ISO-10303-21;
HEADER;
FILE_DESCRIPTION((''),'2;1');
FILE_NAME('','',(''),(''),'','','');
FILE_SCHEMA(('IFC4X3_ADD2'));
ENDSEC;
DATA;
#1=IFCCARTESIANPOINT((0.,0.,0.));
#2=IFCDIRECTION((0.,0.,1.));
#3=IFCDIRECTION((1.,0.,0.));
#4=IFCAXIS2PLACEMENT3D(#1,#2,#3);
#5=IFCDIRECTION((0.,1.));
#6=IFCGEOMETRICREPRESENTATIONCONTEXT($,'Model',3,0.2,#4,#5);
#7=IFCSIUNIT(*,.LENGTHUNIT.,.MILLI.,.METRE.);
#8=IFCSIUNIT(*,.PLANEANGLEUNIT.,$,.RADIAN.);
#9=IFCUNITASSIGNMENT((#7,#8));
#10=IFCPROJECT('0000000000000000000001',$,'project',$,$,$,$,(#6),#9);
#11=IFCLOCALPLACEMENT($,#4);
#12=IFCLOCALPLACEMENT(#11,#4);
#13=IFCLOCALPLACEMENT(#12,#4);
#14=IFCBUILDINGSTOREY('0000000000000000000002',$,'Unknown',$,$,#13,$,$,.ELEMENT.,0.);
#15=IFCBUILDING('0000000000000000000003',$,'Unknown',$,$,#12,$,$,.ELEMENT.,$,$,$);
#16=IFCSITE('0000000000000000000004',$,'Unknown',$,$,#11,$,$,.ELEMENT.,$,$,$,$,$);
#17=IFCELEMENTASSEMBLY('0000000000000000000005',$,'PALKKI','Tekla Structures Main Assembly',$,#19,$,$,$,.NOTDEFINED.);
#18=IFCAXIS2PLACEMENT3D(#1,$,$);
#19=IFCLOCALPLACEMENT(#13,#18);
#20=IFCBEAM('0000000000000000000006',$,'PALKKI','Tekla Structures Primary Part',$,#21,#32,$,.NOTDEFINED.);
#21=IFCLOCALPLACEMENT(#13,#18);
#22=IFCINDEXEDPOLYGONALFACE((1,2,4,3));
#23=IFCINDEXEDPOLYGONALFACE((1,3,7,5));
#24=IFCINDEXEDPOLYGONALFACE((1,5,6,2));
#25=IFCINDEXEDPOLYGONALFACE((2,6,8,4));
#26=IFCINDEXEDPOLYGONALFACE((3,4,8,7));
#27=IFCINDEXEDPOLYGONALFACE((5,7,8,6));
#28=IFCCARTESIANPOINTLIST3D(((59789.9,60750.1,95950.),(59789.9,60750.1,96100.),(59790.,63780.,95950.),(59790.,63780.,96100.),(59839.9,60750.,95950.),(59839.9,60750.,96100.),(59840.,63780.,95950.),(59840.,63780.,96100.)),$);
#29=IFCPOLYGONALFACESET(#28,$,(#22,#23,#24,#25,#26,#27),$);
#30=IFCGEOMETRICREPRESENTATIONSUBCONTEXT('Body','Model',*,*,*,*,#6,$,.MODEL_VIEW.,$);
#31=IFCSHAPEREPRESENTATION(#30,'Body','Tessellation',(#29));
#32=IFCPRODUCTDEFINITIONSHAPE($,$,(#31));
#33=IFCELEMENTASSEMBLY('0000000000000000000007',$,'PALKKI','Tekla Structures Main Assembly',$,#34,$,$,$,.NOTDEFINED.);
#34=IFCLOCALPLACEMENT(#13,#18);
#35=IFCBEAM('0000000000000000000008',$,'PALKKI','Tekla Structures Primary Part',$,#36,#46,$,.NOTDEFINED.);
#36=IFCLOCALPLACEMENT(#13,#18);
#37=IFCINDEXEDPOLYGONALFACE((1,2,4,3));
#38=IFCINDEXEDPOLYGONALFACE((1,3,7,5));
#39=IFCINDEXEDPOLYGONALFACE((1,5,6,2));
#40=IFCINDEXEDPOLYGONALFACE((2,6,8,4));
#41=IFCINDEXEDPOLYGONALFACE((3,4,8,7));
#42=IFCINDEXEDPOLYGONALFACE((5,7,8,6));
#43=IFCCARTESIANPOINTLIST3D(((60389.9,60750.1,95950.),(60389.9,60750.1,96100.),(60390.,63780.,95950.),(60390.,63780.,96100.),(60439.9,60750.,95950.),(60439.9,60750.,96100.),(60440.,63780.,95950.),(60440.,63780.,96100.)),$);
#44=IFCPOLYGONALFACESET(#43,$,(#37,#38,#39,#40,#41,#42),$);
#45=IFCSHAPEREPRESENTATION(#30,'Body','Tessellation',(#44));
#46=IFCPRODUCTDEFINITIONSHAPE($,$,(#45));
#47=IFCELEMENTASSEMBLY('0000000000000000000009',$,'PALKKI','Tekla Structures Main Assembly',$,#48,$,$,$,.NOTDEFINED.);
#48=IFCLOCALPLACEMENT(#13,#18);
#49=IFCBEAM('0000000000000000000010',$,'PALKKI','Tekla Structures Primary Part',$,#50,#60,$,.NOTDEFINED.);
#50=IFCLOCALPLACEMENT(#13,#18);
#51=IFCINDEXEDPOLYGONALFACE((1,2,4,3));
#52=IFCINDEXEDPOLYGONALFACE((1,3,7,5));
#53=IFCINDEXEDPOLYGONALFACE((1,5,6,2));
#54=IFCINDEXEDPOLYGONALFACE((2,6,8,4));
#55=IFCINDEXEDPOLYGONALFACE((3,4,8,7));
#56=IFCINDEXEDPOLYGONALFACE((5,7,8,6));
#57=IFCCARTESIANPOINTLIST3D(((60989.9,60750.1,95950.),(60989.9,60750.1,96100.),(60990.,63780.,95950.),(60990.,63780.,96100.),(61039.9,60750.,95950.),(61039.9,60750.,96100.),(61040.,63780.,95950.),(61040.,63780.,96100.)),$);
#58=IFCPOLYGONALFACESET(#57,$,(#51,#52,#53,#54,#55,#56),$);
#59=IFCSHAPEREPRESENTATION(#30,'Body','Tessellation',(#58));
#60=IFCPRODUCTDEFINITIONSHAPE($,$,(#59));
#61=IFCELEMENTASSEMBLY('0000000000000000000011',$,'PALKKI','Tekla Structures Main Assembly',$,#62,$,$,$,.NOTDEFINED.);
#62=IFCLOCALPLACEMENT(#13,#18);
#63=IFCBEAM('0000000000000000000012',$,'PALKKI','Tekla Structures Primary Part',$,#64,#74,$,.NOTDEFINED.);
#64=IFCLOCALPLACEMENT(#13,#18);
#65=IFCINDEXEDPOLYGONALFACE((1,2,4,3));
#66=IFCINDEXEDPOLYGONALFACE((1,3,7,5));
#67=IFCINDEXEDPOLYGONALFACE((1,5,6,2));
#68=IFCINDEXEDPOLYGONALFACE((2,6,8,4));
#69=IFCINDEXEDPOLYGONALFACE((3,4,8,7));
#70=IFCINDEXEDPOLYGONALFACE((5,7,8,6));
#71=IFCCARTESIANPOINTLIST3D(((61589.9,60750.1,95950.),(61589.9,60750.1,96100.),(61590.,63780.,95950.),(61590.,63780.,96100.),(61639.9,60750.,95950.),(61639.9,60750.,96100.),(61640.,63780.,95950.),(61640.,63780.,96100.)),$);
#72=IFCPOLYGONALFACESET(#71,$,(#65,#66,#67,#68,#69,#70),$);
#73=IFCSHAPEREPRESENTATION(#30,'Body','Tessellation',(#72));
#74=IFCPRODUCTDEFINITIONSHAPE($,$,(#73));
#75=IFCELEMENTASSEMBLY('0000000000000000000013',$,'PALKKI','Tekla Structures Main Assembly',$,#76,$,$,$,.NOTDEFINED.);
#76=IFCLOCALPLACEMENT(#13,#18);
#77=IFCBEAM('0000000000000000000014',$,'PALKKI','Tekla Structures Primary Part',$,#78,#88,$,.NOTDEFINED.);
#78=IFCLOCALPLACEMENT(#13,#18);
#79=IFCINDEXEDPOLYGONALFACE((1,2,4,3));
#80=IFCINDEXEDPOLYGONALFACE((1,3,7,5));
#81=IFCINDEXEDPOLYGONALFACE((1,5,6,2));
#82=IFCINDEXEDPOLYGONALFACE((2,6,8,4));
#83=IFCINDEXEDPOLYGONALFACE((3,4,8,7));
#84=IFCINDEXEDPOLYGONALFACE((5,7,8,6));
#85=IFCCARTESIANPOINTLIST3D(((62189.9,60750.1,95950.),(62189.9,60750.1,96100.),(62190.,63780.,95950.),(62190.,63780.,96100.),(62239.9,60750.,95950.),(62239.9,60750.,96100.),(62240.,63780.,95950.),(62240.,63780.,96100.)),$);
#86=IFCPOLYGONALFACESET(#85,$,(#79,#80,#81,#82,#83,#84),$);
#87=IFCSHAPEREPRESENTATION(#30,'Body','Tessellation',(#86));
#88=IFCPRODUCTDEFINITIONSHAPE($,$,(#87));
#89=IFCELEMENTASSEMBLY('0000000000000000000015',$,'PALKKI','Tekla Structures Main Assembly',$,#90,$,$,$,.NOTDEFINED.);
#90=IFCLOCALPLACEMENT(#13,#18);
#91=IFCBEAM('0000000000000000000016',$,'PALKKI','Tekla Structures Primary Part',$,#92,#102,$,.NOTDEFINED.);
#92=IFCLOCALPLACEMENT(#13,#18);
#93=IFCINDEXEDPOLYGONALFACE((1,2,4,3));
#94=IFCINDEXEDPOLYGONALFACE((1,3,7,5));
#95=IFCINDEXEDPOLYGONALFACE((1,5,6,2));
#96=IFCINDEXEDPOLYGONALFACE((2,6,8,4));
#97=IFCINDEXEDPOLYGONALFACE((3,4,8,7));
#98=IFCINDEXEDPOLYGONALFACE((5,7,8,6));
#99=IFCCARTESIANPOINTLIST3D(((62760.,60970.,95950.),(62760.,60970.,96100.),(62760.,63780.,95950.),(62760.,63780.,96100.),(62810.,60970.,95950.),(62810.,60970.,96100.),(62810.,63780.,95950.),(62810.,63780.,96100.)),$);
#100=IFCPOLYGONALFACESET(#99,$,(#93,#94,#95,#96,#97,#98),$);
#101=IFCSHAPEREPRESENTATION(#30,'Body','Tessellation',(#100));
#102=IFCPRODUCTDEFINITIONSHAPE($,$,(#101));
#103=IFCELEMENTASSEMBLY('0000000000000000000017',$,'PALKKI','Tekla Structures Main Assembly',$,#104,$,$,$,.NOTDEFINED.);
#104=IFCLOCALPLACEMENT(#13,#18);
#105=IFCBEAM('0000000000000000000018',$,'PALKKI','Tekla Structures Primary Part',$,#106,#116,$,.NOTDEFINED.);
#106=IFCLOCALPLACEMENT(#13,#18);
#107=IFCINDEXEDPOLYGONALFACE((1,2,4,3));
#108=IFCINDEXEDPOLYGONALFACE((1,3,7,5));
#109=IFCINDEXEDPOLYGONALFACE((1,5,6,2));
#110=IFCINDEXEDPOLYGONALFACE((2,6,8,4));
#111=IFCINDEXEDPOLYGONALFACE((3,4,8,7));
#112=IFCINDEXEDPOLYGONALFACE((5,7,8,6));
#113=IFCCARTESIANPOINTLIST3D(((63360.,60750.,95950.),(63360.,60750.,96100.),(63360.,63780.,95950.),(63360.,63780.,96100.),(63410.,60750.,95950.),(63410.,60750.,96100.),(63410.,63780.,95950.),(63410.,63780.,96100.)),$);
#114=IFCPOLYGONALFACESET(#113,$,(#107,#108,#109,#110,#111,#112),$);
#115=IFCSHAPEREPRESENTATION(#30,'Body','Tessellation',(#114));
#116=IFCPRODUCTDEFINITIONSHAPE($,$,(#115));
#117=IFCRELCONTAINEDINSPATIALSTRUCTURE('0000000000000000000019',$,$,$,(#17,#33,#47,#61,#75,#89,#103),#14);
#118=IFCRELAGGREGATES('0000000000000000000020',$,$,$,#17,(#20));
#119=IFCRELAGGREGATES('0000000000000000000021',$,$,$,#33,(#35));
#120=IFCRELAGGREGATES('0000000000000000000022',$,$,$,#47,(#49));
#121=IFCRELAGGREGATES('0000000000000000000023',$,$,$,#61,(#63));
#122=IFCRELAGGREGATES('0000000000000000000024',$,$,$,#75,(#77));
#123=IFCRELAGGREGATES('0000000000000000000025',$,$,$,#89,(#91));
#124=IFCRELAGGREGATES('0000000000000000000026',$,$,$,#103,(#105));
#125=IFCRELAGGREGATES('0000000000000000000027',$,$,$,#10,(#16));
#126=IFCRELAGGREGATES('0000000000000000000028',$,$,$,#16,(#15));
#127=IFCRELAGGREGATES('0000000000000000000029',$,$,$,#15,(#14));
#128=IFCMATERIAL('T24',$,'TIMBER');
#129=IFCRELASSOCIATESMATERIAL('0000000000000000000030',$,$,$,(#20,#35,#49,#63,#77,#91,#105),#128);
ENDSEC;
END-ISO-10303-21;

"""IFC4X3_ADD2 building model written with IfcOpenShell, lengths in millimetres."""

from ifc_helpers import new_model, si_unit, direction, frame, origin_with_axes, place, context, subcontext, project, spatial, line, indexed_curve, outline, extrude, material, element, aggregate, save


model = new_model("IFC4X3_ADD2")

# Units and contexts
model_context = context("Model", 3, precision=0.2, world=origin_with_axes(), true_north=direction((0.0, 1.0)))
body_context = subcontext(model_context, "Body", "Model", "MODEL_VIEW")
ifc_project = project(units=[si_unit("LENGTHUNIT", "METRE", prefix="MILLI"), si_unit("PLANEANGLEUNIT", "RADIAN")], contexts=[model_context])

# Site, building, storey
site_placement = place(None, origin_with_axes())
site = spatial("IfcSite", under=ifc_project, at=site_placement, Name="Unknown", CompositionType="ELEMENT")
building_placement = place(site_placement, origin_with_axes())
building = spatial("IfcBuilding", under=site, at=building_placement, Name="Unknown", CompositionType="ELEMENT")
storey_placement = place(building_placement, origin_with_axes())
storey = spatial("IfcBuildingStorey", under=building, at=storey_placement, Name="Unknown", CompositionType="ELEMENT", Elevation=0.0)

# Element assemblies, beams
ifc_material_1 = material(Name="T24", Category="TIMBER")
assembly_1_placement = place(storey_placement, frame((59815.0, 63780.0, 96025.0), z_axis=(-1.0, 0.000016, 0.0), x_axis=(-0.000016, -1.0, 0.0)))
assembly_1 = element("IfcElementAssembly", 1, at=assembly_1_placement, inside=storey, Name="PALKKI", Description="Tekla Structures Main Assembly", PredefinedType="NOTDEFINED")
beam_1_placement = place(assembly_1_placement, origin_with_axes())
beam_1 = element("IfcBeam", 2, at=beam_1_placement, material=ifc_material_1, Name="PALKKI", Description="Tekla Structures Primary Part", PredefinedType="NOTDEFINED", context=body_context, shape_type="SolidModel", body=[
    extrude(outline(indexed_curve([(-25.0, -75.0), (25.0, -75.0), (25.0, 75.0), (-25.0, 75.0)], segments=[line(1, 2, 3, 4, 1)])), frame((0.0, 0.0, 0.0), z_axis=(-1.0, 0.0, 0.0), x_axis=(0.0, 0.0, 1.0)), (0.0, 0.0, -1.0), 3029.9),
])
aggregate(assembly_1, [beam_1])
assembly_2_placement = place(storey_placement, frame((60415.0, 63780.0, 96025.0), z_axis=(-1.0, 0.000016, 0.0), x_axis=(-0.000016, -1.0, 0.0)))
assembly_2 = element("IfcElementAssembly", 3, at=assembly_2_placement, inside=storey, Name="PALKKI", Description="Tekla Structures Main Assembly", PredefinedType="NOTDEFINED")
beam_2_placement = place(assembly_2_placement, origin_with_axes())
beam_2 = element("IfcBeam", 4, at=beam_2_placement, material=ifc_material_1, Name="PALKKI", Description="Tekla Structures Primary Part", PredefinedType="NOTDEFINED", context=body_context, shape_type="SolidModel", body=[
    extrude(outline(indexed_curve([(-25.0, -75.0), (25.0, -75.0), (25.0, 75.0), (-25.0, 75.0)], segments=[line(1, 2, 3, 4, 1)])), frame((0.0, 0.0, 0.0), z_axis=(-1.0, 0.0, 0.0), x_axis=(0.0, 0.0, 1.0)), (0.0, 0.0, -1.0), 3029.9),
])
aggregate(assembly_2, [beam_2])
assembly_3_placement = place(storey_placement, frame((61015.0, 63780.0, 96025.0), z_axis=(-1.0, 0.000016, 0.0), x_axis=(-0.000016, -1.0, 0.0)))
assembly_3 = element("IfcElementAssembly", 5, at=assembly_3_placement, inside=storey, Name="PALKKI", Description="Tekla Structures Main Assembly", PredefinedType="NOTDEFINED")
beam_3_placement = place(assembly_3_placement, origin_with_axes())
beam_3 = element("IfcBeam", 6, at=beam_3_placement, material=ifc_material_1, Name="PALKKI", Description="Tekla Structures Primary Part", PredefinedType="NOTDEFINED", context=body_context, shape_type="SolidModel", body=[
    extrude(outline(indexed_curve([(-25.0, -75.0), (25.0, -75.0), (25.0, 75.0), (-25.0, 75.0)], segments=[line(1, 2, 3, 4, 1)])), frame((0.0, 0.0, 0.0), z_axis=(-1.0, 0.0, 0.0), x_axis=(0.0, 0.0, 1.0)), (0.0, 0.0, -1.0), 3029.9),
])
aggregate(assembly_3, [beam_3])
assembly_4_placement = place(storey_placement, frame((61615.0, 63780.0, 96025.0), z_axis=(-1.0, 0.000016, 0.0), x_axis=(-0.000016, -1.0, 0.0)))
assembly_4 = element("IfcElementAssembly", 7, at=assembly_4_placement, inside=storey, Name="PALKKI", Description="Tekla Structures Main Assembly", PredefinedType="NOTDEFINED")
beam_4_placement = place(assembly_4_placement, origin_with_axes())
beam_4 = element("IfcBeam", 8, at=beam_4_placement, material=ifc_material_1, Name="PALKKI", Description="Tekla Structures Primary Part", PredefinedType="NOTDEFINED", context=body_context, shape_type="SolidModel", body=[
    extrude(outline(indexed_curve([(-25.0, -75.0), (25.0, -75.0), (25.0, 75.0), (-25.0, 75.0)], segments=[line(1, 2, 3, 4, 1)])), frame((0.0, 0.0, 0.0), z_axis=(-1.0, 0.0, 0.0), x_axis=(0.0, 0.0, 1.0)), (0.0, 0.0, -1.0), 3029.9),
])
aggregate(assembly_4, [beam_4])
assembly_5_placement = place(storey_placement, frame((62215.0, 63780.0, 96025.0), z_axis=(-1.0, 0.000016, 0.0), x_axis=(-0.000016, -1.0, 0.0)))
assembly_5 = element("IfcElementAssembly", 9, at=assembly_5_placement, inside=storey, Name="PALKKI", Description="Tekla Structures Main Assembly", PredefinedType="NOTDEFINED")
beam_5_placement = place(assembly_5_placement, origin_with_axes())
beam_5 = element("IfcBeam", 10, at=beam_5_placement, material=ifc_material_1, Name="PALKKI", Description="Tekla Structures Primary Part", PredefinedType="NOTDEFINED", context=body_context, shape_type="SolidModel", body=[
    extrude(outline(indexed_curve([(-25.0, -75.0), (25.0, -75.0), (25.0, 75.0), (-25.0, 75.0)], segments=[line(1, 2, 3, 4, 1)])), frame((0.0, 0.0, 0.0), z_axis=(-1.0, 0.0, 0.0), x_axis=(0.0, 0.0, 1.0)), (0.0, 0.0, -1.0), 3029.9),
])
aggregate(assembly_5, [beam_5])
assembly_6_placement = place(storey_placement, frame((62785.0, 63780.0, 96025.0), z_axis=(-1.0, 0.000016, 0.0), x_axis=(-0.000016, -1.0, 0.0)))
assembly_6 = element("IfcElementAssembly", 11, at=assembly_6_placement, inside=storey, Name="PALKKI", Description="Tekla Structures Main Assembly", PredefinedType="NOTDEFINED")
beam_6_placement = place(assembly_6_placement, origin_with_axes())
beam_6 = element("IfcBeam", 12, at=beam_6_placement, material=ifc_material_1, Name="PALKKI", Description="Tekla Structures Primary Part", PredefinedType="NOTDEFINED", context=body_context, shape_type="SolidModel", body=[
    extrude(outline(indexed_curve([(-25.0, -75.0), (25.0, -75.0), (25.0, 75.0), (-25.0, 75.0)], segments=[line(1, 2, 3, 4, 1)])), frame((0.0, 0.0, 0.0), z_axis=(-1.0, 0.0, 0.0), x_axis=(0.0, 0.0, 1.0)), (0.0, 0.0, -1.0), 2809.9),
])
aggregate(assembly_6, [beam_6])
assembly_7_placement = place(storey_placement, frame((63385.0, 63780.0, 96025.0), z_axis=(-1.0, 0.000015, 0.0), x_axis=(-0.000015, -1.0, 0.0)))
assembly_7 = element("IfcElementAssembly", 13, at=assembly_7_placement, inside=storey, Name="PALKKI", Description="Tekla Structures Main Assembly", PredefinedType="NOTDEFINED")
beam_7_placement = place(assembly_7_placement, origin_with_axes())
beam_7 = element("IfcBeam", 14, at=beam_7_placement, material=ifc_material_1, Name="PALKKI", Description="Tekla Structures Primary Part", PredefinedType="NOTDEFINED", context=body_context, shape_type="SolidModel", body=[
    extrude(outline(indexed_curve([(-25.0, -75.0), (25.0, -75.0), (25.0, 75.0), (-25.0, 75.0)], segments=[line(1, 2, 3, 4, 1)])), frame((0.0, 0.0, 0.0), z_axis=(-1.0, 0.0, 0.0), x_axis=(0.0, 0.0, 1.0)), (0.0, 0.0, -1.0), 3029.9),
])
aggregate(assembly_7, [beam_7])

save(model, "model.ifc")
